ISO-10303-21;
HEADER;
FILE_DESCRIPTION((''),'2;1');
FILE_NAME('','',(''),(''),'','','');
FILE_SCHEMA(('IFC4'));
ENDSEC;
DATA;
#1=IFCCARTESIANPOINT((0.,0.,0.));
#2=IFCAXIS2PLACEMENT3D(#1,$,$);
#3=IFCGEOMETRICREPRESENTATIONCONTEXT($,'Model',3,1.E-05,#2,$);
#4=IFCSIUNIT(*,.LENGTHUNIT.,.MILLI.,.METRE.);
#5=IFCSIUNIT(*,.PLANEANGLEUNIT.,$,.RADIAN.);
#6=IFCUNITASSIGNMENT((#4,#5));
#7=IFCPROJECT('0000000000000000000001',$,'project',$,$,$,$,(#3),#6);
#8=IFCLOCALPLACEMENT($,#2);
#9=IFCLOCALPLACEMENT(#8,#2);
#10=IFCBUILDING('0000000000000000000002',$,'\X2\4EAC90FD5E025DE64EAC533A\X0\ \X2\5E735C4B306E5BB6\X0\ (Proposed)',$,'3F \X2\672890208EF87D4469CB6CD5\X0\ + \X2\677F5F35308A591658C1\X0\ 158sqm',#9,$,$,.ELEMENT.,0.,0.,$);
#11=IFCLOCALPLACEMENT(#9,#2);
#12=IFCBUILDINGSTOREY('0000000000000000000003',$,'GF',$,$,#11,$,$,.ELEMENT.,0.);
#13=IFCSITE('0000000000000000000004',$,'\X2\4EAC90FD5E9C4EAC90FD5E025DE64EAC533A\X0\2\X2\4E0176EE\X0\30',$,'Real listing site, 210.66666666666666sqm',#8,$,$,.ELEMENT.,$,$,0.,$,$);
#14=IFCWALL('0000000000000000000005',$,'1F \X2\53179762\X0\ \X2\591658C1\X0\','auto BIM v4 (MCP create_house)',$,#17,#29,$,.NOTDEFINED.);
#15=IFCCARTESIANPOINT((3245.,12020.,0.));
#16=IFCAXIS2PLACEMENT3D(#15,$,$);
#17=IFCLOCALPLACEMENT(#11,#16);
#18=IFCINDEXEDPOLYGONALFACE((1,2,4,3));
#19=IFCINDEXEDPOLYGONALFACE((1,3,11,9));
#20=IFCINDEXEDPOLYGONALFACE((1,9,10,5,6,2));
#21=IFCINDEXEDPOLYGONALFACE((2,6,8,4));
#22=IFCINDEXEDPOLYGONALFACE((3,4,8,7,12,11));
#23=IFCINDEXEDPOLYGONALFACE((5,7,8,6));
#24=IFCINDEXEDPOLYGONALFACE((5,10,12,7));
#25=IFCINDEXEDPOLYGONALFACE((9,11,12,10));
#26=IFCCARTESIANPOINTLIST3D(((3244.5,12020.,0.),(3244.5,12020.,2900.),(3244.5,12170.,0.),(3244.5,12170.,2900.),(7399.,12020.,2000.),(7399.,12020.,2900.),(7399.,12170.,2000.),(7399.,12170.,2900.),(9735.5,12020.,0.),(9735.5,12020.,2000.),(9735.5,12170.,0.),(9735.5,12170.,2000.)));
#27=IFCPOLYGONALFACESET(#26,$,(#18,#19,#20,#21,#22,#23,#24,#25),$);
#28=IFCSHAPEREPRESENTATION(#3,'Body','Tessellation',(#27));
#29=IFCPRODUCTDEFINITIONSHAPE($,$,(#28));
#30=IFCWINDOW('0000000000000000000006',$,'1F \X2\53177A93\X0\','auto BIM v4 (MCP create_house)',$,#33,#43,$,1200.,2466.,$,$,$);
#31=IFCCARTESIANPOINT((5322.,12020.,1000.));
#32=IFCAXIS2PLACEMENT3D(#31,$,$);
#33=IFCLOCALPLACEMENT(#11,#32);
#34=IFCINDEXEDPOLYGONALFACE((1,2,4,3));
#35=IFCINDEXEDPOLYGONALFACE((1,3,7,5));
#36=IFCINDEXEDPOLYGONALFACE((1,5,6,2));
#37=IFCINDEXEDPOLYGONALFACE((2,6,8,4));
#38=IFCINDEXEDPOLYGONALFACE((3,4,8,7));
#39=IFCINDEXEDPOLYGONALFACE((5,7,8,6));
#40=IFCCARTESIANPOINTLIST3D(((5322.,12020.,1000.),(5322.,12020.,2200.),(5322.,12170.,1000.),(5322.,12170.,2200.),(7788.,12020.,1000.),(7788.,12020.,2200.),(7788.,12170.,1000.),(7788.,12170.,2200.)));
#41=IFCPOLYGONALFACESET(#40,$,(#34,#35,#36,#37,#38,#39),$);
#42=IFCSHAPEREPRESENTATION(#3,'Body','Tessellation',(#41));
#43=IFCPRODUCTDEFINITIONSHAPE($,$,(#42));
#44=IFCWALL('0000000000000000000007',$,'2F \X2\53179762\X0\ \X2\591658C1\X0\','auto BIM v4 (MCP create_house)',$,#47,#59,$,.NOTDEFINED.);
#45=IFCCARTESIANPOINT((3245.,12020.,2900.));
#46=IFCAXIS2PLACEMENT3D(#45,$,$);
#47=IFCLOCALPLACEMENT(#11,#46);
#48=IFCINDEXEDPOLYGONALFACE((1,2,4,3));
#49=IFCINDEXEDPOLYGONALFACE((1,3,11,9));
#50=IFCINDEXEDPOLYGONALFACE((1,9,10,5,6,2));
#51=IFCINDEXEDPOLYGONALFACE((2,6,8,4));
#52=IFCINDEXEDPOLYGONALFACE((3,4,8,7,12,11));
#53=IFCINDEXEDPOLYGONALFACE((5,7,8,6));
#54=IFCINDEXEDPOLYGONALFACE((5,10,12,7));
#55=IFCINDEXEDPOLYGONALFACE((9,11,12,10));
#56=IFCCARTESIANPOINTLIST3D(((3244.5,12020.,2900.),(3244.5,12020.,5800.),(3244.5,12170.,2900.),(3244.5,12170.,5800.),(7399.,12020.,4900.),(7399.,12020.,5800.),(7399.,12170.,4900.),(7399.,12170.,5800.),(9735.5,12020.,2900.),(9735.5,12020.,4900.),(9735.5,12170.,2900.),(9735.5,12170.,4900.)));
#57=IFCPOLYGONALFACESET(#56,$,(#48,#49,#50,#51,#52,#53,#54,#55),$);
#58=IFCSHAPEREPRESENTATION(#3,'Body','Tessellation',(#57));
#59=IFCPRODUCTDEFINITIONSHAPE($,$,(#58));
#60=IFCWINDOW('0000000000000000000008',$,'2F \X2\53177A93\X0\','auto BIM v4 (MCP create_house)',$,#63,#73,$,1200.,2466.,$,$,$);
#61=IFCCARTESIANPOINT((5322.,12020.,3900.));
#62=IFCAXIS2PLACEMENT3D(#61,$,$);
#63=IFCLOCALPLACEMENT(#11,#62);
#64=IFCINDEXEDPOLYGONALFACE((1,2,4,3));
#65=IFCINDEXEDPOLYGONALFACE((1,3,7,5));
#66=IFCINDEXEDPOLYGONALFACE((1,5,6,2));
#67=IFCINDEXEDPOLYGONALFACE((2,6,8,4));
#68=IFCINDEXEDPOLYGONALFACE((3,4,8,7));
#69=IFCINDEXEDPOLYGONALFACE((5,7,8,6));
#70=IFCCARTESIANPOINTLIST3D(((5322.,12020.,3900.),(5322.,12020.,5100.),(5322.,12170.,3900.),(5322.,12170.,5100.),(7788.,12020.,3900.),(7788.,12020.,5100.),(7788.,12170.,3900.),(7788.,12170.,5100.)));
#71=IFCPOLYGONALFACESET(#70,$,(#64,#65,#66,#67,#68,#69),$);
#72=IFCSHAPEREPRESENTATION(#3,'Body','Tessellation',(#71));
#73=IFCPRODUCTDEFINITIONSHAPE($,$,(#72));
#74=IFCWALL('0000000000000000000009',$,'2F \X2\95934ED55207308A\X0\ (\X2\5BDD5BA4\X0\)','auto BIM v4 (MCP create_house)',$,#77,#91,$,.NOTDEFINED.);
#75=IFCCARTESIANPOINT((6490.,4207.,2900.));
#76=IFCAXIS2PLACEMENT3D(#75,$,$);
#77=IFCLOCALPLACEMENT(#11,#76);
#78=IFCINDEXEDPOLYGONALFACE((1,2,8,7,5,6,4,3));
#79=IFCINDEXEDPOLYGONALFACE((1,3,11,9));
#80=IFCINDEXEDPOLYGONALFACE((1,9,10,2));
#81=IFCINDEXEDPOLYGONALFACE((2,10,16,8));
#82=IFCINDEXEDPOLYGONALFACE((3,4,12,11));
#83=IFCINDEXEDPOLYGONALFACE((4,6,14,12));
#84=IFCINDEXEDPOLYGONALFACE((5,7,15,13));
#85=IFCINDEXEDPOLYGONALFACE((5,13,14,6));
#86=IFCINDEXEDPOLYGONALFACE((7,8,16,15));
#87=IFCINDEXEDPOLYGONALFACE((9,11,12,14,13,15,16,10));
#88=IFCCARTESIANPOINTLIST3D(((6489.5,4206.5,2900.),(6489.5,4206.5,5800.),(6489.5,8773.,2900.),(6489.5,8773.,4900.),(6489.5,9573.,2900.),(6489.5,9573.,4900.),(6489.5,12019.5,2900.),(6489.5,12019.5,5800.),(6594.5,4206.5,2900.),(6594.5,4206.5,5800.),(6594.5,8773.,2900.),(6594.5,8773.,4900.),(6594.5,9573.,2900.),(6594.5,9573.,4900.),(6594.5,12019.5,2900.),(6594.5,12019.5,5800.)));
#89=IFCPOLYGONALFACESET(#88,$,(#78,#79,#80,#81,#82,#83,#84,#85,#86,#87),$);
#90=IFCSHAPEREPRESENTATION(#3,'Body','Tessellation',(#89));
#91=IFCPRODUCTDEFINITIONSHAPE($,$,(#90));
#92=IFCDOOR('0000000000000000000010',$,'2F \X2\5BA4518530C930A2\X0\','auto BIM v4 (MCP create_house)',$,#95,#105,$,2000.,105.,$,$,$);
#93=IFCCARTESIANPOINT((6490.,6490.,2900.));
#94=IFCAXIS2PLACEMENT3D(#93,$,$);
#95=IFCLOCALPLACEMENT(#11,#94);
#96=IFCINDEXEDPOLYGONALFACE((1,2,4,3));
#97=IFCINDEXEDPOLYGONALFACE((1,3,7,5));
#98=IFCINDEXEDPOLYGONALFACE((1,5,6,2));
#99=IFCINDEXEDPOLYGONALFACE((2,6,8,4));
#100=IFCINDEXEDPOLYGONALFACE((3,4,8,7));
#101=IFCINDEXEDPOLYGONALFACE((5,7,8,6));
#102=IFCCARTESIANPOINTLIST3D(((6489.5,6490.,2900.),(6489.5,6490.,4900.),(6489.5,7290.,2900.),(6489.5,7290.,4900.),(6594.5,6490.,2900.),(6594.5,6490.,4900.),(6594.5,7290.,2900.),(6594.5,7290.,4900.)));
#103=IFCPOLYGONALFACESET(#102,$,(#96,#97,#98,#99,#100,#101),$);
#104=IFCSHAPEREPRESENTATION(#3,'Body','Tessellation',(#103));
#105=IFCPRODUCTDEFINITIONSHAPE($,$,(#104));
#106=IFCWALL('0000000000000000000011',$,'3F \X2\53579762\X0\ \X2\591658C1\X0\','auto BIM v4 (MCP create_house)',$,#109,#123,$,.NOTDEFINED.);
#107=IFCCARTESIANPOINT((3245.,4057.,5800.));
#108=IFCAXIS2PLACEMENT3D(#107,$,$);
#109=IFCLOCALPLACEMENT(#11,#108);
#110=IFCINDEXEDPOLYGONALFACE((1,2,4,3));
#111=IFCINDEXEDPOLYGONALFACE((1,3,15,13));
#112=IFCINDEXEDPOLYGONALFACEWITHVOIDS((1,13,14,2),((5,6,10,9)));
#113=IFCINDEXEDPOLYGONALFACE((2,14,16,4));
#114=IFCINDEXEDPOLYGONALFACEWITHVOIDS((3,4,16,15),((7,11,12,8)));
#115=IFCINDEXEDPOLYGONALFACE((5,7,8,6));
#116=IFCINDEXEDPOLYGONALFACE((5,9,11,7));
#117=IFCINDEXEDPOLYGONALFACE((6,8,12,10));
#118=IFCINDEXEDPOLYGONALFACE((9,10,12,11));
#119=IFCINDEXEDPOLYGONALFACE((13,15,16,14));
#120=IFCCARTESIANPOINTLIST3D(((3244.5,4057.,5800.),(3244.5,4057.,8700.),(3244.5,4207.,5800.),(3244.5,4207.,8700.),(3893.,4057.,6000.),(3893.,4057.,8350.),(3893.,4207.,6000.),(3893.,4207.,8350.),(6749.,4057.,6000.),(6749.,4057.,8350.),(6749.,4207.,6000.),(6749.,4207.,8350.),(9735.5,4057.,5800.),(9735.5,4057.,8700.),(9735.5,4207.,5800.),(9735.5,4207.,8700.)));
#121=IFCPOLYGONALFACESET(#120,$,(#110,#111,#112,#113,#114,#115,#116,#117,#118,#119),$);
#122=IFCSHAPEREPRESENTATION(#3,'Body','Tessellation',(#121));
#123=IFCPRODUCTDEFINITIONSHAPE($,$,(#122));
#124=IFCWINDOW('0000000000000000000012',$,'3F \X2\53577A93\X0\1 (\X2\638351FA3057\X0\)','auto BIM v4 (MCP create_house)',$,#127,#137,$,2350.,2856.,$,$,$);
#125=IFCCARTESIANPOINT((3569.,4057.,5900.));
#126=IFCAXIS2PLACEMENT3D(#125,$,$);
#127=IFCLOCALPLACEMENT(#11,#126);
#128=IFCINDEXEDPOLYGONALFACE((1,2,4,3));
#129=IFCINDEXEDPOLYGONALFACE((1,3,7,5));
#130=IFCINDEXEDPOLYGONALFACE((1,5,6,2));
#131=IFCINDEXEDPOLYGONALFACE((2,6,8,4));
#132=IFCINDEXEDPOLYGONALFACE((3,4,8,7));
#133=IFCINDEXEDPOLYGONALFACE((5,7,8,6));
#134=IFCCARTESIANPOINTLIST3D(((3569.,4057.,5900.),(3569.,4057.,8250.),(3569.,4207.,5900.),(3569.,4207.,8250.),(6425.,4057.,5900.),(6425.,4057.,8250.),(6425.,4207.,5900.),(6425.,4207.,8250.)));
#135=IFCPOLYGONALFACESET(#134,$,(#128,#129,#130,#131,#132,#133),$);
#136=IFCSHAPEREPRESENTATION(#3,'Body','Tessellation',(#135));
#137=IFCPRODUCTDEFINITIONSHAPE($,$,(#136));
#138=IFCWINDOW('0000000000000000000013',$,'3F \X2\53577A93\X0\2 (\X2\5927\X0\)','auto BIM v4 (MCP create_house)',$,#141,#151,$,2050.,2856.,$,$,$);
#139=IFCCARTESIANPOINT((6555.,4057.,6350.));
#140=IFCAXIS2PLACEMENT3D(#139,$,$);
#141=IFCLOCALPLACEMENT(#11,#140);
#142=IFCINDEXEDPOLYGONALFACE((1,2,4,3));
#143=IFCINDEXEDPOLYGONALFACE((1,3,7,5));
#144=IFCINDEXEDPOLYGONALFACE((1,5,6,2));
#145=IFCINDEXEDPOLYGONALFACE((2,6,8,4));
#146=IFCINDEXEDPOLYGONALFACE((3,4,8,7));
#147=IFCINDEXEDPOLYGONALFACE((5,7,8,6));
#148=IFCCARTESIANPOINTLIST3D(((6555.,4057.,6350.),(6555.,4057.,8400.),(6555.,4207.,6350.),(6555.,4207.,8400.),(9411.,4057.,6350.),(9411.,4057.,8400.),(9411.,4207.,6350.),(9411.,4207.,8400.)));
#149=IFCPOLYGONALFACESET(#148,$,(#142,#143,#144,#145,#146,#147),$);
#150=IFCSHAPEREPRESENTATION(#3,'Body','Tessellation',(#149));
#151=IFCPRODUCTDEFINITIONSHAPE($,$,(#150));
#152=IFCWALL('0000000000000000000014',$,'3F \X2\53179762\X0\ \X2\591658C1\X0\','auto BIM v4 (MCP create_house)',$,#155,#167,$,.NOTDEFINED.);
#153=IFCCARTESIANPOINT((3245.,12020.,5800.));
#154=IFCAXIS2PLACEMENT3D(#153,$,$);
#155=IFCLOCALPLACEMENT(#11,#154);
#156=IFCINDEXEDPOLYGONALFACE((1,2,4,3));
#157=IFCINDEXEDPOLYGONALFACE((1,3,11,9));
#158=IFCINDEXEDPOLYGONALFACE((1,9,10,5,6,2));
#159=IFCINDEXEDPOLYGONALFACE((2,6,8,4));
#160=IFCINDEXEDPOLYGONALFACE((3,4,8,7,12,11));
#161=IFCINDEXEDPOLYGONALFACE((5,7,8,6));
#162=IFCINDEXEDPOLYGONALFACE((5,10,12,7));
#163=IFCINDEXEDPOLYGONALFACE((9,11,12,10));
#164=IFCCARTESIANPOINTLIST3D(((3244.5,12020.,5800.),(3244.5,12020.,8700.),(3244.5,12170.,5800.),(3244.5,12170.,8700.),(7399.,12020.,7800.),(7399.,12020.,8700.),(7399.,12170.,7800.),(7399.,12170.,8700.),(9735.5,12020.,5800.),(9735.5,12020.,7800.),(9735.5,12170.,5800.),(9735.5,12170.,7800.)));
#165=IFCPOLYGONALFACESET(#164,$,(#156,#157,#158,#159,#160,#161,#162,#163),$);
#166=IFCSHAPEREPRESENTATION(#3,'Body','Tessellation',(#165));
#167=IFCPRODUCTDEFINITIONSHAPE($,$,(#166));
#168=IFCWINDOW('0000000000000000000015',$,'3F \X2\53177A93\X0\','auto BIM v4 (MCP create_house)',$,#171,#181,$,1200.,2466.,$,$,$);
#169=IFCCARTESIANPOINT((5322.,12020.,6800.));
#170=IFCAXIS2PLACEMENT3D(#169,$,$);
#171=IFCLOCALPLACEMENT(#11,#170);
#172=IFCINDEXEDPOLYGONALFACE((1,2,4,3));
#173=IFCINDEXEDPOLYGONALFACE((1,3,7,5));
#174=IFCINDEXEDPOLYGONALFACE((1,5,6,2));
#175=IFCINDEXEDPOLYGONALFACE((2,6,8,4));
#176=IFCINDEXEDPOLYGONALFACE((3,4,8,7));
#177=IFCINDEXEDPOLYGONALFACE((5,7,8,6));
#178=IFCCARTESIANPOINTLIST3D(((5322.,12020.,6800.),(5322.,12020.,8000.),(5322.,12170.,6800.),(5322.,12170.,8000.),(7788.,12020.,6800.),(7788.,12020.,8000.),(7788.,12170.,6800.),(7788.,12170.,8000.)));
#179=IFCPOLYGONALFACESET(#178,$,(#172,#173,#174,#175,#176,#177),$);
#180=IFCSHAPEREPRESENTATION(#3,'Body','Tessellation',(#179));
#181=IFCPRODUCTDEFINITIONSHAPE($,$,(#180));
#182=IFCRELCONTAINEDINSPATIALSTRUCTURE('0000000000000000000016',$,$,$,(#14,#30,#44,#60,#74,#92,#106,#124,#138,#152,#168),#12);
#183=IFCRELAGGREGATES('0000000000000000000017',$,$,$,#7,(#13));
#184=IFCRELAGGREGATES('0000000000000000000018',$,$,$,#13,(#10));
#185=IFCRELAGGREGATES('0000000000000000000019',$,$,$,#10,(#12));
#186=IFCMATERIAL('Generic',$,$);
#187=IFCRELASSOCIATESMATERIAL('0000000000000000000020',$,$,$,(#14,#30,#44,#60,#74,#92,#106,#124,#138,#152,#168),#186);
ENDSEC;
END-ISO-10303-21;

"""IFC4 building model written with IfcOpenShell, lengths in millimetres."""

from ifc_helpers import new_model, si_unit, frame, frame_2d, origin, place, context, project, spatial, rectangle, extrude, material, element, fill, save


model = new_model("IFC4")

# Units and contexts
model_context = context("Model", 3, precision=1e-05, world=origin())
ifc_project = project(units=[si_unit("LENGTHUNIT", "METRE", prefix="MILLI"), si_unit("PLANEANGLEUNIT", "RADIAN")], contexts=[model_context])

# Site, building, storey
site_placement = place(None, origin())
site = spatial("IfcSite", under=ifc_project, at=site_placement, Name="京都府京都市左京区2丁目30", ObjectType="Real listing site, 210.66666666666666sqm", CompositionType="ELEMENT", RefElevation=0.0)
building_placement = place(site_placement, origin())
building = spatial("IfcBuilding", under=site, at=building_placement, Name="京都市左京区 平屋の家 (Proposed)", ObjectType="3F 木造軸組構法 + 板張り外壁 158sqm", CompositionType="ELEMENT", ElevationOfRefHeight=0.0, ElevationOfTerrain=0.0)
storey_placement = place(building_placement, origin())
storey = spatial("IfcBuildingStorey", under=building, at=storey_placement, Name="GF", CompositionType="ELEMENT", Elevation=0.0)

# Shared definitions
ifc_material = material(Name="Generic")

# Wall, opening, window
wall_1_placement = place(storey_placement, frame((3245.0, 12020.0, 0.0)))
wall_1 = element("IfcWall", 1, at=wall_1_placement, inside=storey, material=ifc_material, Name="1F 北面 外壁", Description="auto BIM v4 (MCP create_house)", PredefinedType="NOTDEFINED", context=model_context, shape_type="SweptSolid", body=[
    extrude(rectangle(XDim=6491.0, YDim=150.0, at=frame_2d((3245.0, 75.0))), frame((3245.0, 12020.0, 0.0)), (0.0, 0.0, 1.0), 2900.0),
])
opening_1_placement = place(storey_placement, frame((5322.0, 12020.0, 1000.0)))
opening_1 = element("IfcOpeningElement", 2, at=opening_1_placement, cuts=wall_1, PredefinedType="NOTDEFINED", context=model_context, shape_type="SweptSolid", body=[
    extrude(rectangle(XDim=2466.0, YDim=150.0, at=frame_2d((1233.0, 75.0))), frame((5322.0, 12020.0, 1000.0)), (0.0, 0.0, 1.0), 1200.0),
])
window_1_placement = place(storey_placement, frame((5322.0, 12020.0, 1000.0)))
window_1 = element("IfcWindow", 3, at=window_1_placement, inside=storey, material=ifc_material, Name="1F 北窓", Description="auto BIM v4 (MCP create_house)", OverallHeight=1200.0, OverallWidth=2466.0, context=model_context, shape_type="SweptSolid", body=[
    extrude(rectangle(XDim=2466.0, YDim=150.0, at=frame_2d((1233.0, 75.0))), frame((5322.0, 12020.0, 1000.0)), (0.0, 0.0, 1.0), 1200.0),
])
fill(opening_1, window_1)

# Wall, opening, window
wall_2_placement = place(storey_placement, frame((3245.0, 12020.0, 2900.0)))
wall_2 = element("IfcWall", 4, at=wall_2_placement, inside=storey, material=ifc_material, Name="2F 北面 外壁", Description="auto BIM v4 (MCP create_house)", PredefinedType="NOTDEFINED", context=model_context, shape_type="SweptSolid", body=[
    extrude(rectangle(XDim=6491.0, YDim=150.0, at=frame_2d((3245.0, 75.0))), frame((3245.0, 12020.0, 2900.0)), (0.0, 0.0, 1.0), 2900.0),
])
opening_2_placement = place(storey_placement, frame((5322.0, 12020.0, 3900.0)))
opening_2 = element("IfcOpeningElement", 5, at=opening_2_placement, cuts=wall_2, PredefinedType="NOTDEFINED", context=model_context, shape_type="SweptSolid", body=[
    extrude(rectangle(XDim=2466.0, YDim=150.0, at=frame_2d((1233.0, 75.0))), frame((5322.0, 12020.0, 3900.0)), (0.0, 0.0, 1.0), 1200.0),
])
window_2_placement = place(storey_placement, frame((5322.0, 12020.0, 3900.0)))
window_2 = element("IfcWindow", 6, at=window_2_placement, inside=storey, material=ifc_material, Name="2F 北窓", Description="auto BIM v4 (MCP create_house)", OverallHeight=1200.0, OverallWidth=2466.0, context=model_context, shape_type="SweptSolid", body=[
    extrude(rectangle(XDim=2466.0, YDim=150.0, at=frame_2d((1233.0, 75.0))), frame((5322.0, 12020.0, 3900.0)), (0.0, 0.0, 1.0), 1200.0),
])
fill(opening_2, window_2)

# Wall, opening, door
wall_3_placement = place(storey_placement, frame((6490.0, 4207.0, 2900.0)))
wall_3 = element("IfcWall", 7, at=wall_3_placement, inside=storey, material=ifc_material, Name="2F 間仕切り (寝室)", Description="auto BIM v4 (MCP create_house)", PredefinedType="NOTDEFINED", context=model_context, shape_type="SweptSolid", body=[
    extrude(rectangle(XDim=105.0, YDim=7813.0, at=frame_2d((52.0, 3906.0))), frame((6490.0, 4207.0, 2900.0)), (0.0, 0.0, 1.0), 2900.0),
])
opening_3_placement = place(storey_placement, frame((6490.0, 6490.0, 2900.0)))
opening_3 = element("IfcOpeningElement", 8, at=opening_3_placement, cuts=wall_3, PredefinedType="NOTDEFINED", context=model_context, shape_type="SweptSolid", body=[
    extrude(rectangle(XDim=105.0, YDim=800.0, at=frame_2d((52.0, 400.0))), frame((6490.0, 6490.0, 2900.0)), (0.0, 0.0, 1.0), 2000.0),
])
door_1_placement = place(storey_placement, frame((6490.0, 6490.0, 2900.0)))
door_1 = element("IfcDoor", 9, at=door_1_placement, inside=storey, material=ifc_material, Name="2F 室内ドア", Description="auto BIM v4 (MCP create_house)", OverallHeight=2000.0, OverallWidth=105.0, context=model_context, shape_type="SweptSolid", body=[
    extrude(rectangle(XDim=105.0, YDim=800.0, at=frame_2d((52.0, 400.0))), frame((6490.0, 6490.0, 2900.0)), (0.0, 0.0, 1.0), 2000.0),
])
fill(opening_3, door_1)

# Wall, openings, windows
wall_4_placement = place(storey_placement, frame((3245.0, 4057.0, 5800.0)))
wall_4 = element("IfcWall", 10, at=wall_4_placement, inside=storey, material=ifc_material, Name="3F 南面 外壁", Description="auto BIM v4 (MCP create_house)", PredefinedType="NOTDEFINED", context=model_context, shape_type="SweptSolid", body=[
    extrude(rectangle(XDim=6491.0, YDim=150.0, at=frame_2d((3245.0, 75.0))), frame((3245.0, 4057.0, 5800.0)), (0.0, 0.0, 1.0), 2900.0),
])
opening_4_placement = place(storey_placement, frame((3569.0, 4057.0, 5900.0)))
opening_4 = element("IfcOpeningElement", 11, at=opening_4_placement, cuts=wall_4, PredefinedType="NOTDEFINED", context=model_context, shape_type="SweptSolid", body=[
    extrude(rectangle(XDim=2856.0, YDim=150.0, at=frame_2d((1428.0, 75.0))), frame((3569.0, 4057.0, 5900.0)), (0.0, 0.0, 1.0), 2350.0),
])
opening_5_placement = place(storey_placement, frame((6555.0, 4057.0, 6350.0)))
opening_5 = element("IfcOpeningElement", 12, at=opening_5_placement, cuts=wall_4, PredefinedType="NOTDEFINED", context=model_context, shape_type="SweptSolid", body=[
    extrude(rectangle(XDim=2856.0, YDim=150.0, at=frame_2d((1428.0, 75.0))), frame((6555.0, 4057.0, 6350.0)), (0.0, 0.0, 1.0), 2050.0),
])
window_3_placement = place(storey_placement, frame((3569.0, 4057.0, 5900.0)))
window_3 = element("IfcWindow", 13, at=window_3_placement, inside=storey, material=ifc_material, Name="3F 南窓1 (掃出し)", Description="auto BIM v4 (MCP create_house)", OverallHeight=2350.0, OverallWidth=2856.0, context=model_context, shape_type="SweptSolid", body=[
    extrude(rectangle(XDim=2856.0, YDim=150.0, at=frame_2d((1428.0, 75.0))), frame((3569.0, 4057.0, 5900.0)), (0.0, 0.0, 1.0), 2350.0),
])
fill(opening_4, window_3)
window_4_placement = place(storey_placement, frame((6555.0, 4057.0, 6350.0)))
window_4 = element("IfcWindow", 14, at=window_4_placement, inside=storey, material=ifc_material, Name="3F 南窓2 (大)", Description="auto BIM v4 (MCP create_house)", OverallHeight=2050.0, OverallWidth=2856.0, context=model_context, shape_type="SweptSolid", body=[
    extrude(rectangle(XDim=2856.0, YDim=150.0, at=frame_2d((1428.0, 75.0))), frame((6555.0, 4057.0, 6350.0)), (0.0, 0.0, 1.0), 2050.0),
])
fill(opening_5, window_4)

# Wall, opening, window
wall_5_placement = place(storey_placement, frame((3245.0, 12020.0, 5800.0)))
wall_5 = element("IfcWall", 15, at=wall_5_placement, inside=storey, material=ifc_material, Name="3F 北面 外壁", Description="auto BIM v4 (MCP create_house)", PredefinedType="NOTDEFINED", context=model_context, shape_type="SweptSolid", body=[
    extrude(rectangle(XDim=6491.0, YDim=150.0, at=frame_2d((3245.0, 75.0))), frame((3245.0, 12020.0, 5800.0)), (0.0, 0.0, 1.0), 2900.0),
])
opening_6_placement = place(storey_placement, frame((5322.0, 12020.0, 6800.0)))
opening_6 = element("IfcOpeningElement", 16, at=opening_6_placement, cuts=wall_5, PredefinedType="NOTDEFINED", context=model_context, shape_type="SweptSolid", body=[
    extrude(rectangle(XDim=2466.0, YDim=150.0, at=frame_2d((1233.0, 75.0))), frame((5322.0, 12020.0, 6800.0)), (0.0, 0.0, 1.0), 1200.0),
])
window_5_placement = place(storey_placement, frame((5322.0, 12020.0, 6800.0)))
window_5 = element("IfcWindow", 17, at=window_5_placement, inside=storey, material=ifc_material, Name="3F 北窓", Description="auto BIM v4 (MCP create_house)", OverallHeight=1200.0, OverallWidth=2466.0, context=model_context, shape_type="SweptSolid", body=[
    extrude(rectangle(XDim=2466.0, YDim=150.0, at=frame_2d((1233.0, 75.0))), frame((5322.0, 12020.0, 6800.0)), (0.0, 0.0, 1.0), 1200.0),
])
fill(opening_6, window_5)

save(model, "model.ifc")
